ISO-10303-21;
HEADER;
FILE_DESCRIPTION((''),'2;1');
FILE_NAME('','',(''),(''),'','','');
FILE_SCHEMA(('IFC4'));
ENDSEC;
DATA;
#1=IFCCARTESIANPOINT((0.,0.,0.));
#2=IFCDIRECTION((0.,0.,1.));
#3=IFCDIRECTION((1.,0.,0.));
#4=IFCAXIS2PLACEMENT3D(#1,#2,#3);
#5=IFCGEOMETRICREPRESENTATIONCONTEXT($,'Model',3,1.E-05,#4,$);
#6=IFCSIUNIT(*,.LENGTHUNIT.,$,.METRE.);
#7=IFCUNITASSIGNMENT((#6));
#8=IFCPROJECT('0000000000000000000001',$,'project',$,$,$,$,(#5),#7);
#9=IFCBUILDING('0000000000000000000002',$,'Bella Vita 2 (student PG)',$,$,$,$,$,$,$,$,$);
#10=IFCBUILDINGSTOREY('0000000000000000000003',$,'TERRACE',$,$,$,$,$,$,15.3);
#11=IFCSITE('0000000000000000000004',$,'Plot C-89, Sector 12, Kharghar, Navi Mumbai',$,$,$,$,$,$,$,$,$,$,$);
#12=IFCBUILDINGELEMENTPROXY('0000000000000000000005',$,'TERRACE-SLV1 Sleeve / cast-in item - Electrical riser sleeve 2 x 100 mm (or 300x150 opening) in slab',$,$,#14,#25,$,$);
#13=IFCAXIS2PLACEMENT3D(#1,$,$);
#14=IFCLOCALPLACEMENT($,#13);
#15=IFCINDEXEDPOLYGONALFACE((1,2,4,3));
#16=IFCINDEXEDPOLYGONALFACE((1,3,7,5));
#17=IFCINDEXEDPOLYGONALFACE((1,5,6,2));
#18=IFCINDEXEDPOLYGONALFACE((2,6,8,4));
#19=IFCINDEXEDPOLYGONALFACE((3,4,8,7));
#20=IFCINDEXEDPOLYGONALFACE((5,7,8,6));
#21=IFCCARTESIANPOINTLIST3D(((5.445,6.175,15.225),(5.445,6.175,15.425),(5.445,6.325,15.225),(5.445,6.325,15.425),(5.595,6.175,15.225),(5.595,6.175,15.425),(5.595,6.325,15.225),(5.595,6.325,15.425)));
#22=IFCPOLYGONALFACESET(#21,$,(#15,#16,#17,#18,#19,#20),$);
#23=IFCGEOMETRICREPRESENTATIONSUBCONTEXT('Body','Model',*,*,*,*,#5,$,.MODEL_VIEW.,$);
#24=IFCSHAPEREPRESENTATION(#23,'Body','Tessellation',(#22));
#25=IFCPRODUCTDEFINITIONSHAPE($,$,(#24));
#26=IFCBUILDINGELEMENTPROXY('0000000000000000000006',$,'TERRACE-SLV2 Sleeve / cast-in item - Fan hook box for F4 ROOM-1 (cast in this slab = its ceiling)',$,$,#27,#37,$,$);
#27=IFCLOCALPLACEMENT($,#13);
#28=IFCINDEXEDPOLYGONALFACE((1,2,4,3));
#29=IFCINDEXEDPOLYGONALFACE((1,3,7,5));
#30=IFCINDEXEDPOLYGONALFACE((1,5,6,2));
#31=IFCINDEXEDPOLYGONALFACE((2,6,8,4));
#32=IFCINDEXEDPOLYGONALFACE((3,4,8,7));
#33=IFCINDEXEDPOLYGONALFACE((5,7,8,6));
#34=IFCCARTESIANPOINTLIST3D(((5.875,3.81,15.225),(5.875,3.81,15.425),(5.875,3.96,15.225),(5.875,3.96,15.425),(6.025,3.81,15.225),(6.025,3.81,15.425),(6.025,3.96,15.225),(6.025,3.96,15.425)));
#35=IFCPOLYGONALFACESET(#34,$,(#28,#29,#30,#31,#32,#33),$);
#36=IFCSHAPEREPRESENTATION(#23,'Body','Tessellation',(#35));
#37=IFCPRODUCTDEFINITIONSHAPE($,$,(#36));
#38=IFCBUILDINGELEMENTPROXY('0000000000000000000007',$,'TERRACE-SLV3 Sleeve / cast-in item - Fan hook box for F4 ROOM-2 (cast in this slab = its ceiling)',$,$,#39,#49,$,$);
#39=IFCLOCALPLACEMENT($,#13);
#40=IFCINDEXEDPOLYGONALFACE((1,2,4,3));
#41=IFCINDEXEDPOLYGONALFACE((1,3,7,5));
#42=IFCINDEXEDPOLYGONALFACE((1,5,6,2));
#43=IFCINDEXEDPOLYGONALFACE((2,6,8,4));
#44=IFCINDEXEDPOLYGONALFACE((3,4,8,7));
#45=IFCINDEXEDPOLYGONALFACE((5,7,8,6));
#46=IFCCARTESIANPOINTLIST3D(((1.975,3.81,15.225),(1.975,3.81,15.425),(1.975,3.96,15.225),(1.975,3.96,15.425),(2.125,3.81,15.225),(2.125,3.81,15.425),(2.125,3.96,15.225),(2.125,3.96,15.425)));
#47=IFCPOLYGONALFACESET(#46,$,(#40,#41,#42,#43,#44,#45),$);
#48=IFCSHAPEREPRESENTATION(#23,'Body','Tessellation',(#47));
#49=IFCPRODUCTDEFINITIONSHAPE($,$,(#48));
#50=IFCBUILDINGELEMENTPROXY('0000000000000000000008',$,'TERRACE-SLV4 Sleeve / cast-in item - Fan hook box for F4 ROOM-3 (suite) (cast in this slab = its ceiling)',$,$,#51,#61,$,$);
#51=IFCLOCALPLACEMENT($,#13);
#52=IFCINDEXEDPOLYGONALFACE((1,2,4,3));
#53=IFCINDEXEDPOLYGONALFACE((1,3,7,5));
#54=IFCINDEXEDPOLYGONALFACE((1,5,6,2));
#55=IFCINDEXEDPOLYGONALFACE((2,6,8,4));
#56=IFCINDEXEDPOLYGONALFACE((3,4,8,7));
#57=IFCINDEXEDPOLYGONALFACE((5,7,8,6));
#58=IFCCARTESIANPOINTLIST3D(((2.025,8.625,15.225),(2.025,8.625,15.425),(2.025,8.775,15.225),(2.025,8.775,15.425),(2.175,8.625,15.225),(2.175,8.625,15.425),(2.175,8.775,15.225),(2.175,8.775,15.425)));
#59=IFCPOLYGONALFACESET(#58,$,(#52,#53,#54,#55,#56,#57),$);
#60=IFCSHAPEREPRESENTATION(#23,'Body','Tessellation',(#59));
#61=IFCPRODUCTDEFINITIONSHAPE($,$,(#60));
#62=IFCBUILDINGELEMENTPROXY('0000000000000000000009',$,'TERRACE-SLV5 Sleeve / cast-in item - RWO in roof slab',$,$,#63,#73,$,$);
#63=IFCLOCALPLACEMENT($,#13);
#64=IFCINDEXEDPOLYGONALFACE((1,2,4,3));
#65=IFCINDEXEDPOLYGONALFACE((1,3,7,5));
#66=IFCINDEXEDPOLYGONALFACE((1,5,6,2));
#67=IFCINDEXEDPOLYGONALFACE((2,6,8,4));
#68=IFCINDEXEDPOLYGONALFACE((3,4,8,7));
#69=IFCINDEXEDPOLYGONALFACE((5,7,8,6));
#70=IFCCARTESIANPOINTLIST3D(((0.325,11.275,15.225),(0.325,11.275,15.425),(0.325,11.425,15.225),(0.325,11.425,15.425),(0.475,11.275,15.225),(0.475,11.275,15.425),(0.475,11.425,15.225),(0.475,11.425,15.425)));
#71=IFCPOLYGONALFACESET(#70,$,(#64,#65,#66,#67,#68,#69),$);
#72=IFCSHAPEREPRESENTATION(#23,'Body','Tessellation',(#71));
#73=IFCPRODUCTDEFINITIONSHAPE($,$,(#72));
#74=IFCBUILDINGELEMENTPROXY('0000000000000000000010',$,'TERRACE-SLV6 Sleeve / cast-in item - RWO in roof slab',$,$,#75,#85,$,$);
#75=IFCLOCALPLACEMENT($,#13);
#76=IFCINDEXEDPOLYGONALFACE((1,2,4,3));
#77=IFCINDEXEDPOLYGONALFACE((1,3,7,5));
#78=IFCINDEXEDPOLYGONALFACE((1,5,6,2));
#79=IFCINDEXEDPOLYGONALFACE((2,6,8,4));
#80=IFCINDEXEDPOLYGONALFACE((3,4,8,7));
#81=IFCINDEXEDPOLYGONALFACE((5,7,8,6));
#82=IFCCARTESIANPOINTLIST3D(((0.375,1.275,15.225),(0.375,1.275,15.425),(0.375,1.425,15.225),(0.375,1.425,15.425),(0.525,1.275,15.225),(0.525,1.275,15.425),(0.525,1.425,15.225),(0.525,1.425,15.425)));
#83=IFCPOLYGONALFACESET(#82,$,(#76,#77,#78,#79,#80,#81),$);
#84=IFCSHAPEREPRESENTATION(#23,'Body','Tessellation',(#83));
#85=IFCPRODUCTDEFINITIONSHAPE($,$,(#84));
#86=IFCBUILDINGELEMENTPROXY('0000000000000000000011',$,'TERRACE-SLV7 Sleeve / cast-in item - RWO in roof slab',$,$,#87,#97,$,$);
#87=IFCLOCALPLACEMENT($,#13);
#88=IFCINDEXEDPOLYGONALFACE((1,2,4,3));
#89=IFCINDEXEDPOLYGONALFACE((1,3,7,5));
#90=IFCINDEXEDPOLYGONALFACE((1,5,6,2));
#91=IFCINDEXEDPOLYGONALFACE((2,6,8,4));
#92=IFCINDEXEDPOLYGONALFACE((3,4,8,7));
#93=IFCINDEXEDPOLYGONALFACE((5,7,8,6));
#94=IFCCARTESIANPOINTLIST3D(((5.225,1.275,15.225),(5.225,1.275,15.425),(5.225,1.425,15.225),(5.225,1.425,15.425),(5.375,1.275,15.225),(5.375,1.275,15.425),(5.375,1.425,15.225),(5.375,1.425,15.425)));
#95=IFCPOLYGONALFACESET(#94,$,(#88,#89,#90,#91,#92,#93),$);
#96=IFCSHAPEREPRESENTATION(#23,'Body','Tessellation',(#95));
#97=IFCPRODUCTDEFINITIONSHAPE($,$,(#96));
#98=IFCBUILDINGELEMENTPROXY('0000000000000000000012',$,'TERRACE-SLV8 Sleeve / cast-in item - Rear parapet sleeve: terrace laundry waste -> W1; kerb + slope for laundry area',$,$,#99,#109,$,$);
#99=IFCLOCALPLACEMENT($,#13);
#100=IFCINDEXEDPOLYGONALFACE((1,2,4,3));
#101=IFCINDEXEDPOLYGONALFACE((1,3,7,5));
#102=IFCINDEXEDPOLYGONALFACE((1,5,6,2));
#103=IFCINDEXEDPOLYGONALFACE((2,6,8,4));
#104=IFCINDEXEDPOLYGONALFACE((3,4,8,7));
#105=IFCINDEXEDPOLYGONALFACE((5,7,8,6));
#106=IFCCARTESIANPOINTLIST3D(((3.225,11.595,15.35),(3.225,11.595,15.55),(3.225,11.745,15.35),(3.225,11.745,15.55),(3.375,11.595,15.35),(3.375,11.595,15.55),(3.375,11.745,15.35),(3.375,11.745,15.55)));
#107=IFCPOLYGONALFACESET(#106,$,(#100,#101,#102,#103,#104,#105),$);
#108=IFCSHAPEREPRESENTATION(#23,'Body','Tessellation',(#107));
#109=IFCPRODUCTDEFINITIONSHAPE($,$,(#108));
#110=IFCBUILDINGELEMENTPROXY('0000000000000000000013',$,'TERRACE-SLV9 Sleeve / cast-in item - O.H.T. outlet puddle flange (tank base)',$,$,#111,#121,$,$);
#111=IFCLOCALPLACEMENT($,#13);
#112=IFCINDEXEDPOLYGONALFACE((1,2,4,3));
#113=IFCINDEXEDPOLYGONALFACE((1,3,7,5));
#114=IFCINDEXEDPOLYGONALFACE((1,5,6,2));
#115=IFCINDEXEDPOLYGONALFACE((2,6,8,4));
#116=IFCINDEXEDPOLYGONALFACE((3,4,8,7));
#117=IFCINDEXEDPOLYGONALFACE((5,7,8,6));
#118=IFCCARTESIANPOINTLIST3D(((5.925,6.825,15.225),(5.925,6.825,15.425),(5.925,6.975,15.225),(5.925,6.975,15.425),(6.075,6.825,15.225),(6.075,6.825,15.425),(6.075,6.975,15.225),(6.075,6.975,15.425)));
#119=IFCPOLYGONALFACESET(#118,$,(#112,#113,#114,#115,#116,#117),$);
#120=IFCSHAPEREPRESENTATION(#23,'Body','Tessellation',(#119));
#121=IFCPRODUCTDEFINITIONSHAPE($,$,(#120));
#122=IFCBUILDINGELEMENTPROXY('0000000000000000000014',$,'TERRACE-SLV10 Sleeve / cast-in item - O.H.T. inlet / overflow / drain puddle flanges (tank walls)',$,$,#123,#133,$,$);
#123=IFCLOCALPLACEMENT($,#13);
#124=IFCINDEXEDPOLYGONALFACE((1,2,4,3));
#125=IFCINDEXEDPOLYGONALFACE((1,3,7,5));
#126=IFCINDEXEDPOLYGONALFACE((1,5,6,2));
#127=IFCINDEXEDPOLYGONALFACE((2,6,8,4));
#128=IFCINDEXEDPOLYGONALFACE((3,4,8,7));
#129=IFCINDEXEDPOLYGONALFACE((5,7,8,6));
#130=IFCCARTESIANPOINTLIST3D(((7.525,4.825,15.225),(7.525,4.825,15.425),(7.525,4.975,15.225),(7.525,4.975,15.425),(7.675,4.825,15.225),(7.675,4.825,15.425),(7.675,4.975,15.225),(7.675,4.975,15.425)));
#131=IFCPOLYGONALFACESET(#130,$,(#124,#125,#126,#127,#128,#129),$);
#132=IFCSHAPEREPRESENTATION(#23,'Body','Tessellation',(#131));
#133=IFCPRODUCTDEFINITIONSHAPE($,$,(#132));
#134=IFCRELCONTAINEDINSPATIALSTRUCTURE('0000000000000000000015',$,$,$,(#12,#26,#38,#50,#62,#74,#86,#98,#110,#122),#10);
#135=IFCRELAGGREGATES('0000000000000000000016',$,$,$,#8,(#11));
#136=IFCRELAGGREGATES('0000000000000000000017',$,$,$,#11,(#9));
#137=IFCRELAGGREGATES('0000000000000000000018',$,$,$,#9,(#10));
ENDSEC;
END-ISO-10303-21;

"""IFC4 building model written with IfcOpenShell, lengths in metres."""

from ifc_helpers import new_model, si_unit, frame, origin, origin_with_axes, origin_2d, place, context, subcontext, project, spatial, rectangle, extrude, element, save


model = new_model("IFC4")

# Units and contexts
model_context = context("Model", 3, precision=1e-05, world=origin_with_axes())
body_context = subcontext(model_context, "Body", "Model", "MODEL_VIEW")
ifc_project = project(units=[si_unit("LENGTHUNIT", "METRE")], contexts=[model_context])

# Site, building, storey
site = spatial("IfcSite", under=ifc_project, Name="Plot C-89, Sector 12, Kharghar, Navi Mumbai")
building = spatial("IfcBuilding", under=site, Name="Bella Vita 2 (student PG)")
storey = spatial("IfcBuildingStorey", under=building, Name="TERRACE", Elevation=15.3)

# Building element proxies
proxy_1_placement = place(None, origin())
element("IfcBuildingElementProxy", 1, at=proxy_1_placement, inside=storey, Name="TERRACE-SLV1 Sleeve / cast-in item - Electrical riser sleeve 2 x 100 mm (or 300x150 opening) in slab", context=body_context, shape_type="SweptSolid", body=[
    extrude(rectangle(XDim=0.15, YDim=0.15, at=origin_2d()), frame((5.52, 6.25, 15.225)), (0.0, 0.0, 1.0), 0.2),
])
proxy_2_placement = place(None, origin())
element("IfcBuildingElementProxy", 2, at=proxy_2_placement, inside=storey, Name="TERRACE-SLV2 Sleeve / cast-in item - Fan hook box for F4 ROOM-1 (cast in this slab = its ceiling)", context=body_context, shape_type="SweptSolid", body=[
    extrude(rectangle(XDim=0.15, YDim=0.15, at=origin_2d()), frame((5.95, 3.885, 15.225)), (0.0, 0.0, 1.0), 0.2),
])
proxy_3_placement = place(None, origin())
element("IfcBuildingElementProxy", 3, at=proxy_3_placement, inside=storey, Name="TERRACE-SLV3 Sleeve / cast-in item - Fan hook box for F4 ROOM-2 (cast in this slab = its ceiling)", context=body_context, shape_type="SweptSolid", body=[
    extrude(rectangle(XDim=0.15, YDim=0.15, at=origin_2d()), frame((2.05, 3.885, 15.225)), (0.0, 0.0, 1.0), 0.2),
])
proxy_4_placement = place(None, origin())
element("IfcBuildingElementProxy", 4, at=proxy_4_placement, inside=storey, Name="TERRACE-SLV4 Sleeve / cast-in item - Fan hook box for F4 ROOM-3 (suite) (cast in this slab = its ceiling)", context=body_context, shape_type="SweptSolid", body=[
    extrude(rectangle(XDim=0.15, YDim=0.15, at=origin_2d()), frame((2.1, 8.7, 15.225)), (0.0, 0.0, 1.0), 0.2),
])
proxy_5_placement = place(None, origin())
element("IfcBuildingElementProxy", 5, at=proxy_5_placement, inside=storey, Name="TERRACE-SLV5 Sleeve / cast-in item - RWO in roof slab", context=body_context, shape_type="SweptSolid", body=[
    extrude(rectangle(XDim=0.15, YDim=0.15, at=origin_2d()), frame((0.4, 11.35, 15.225)), (0.0, 0.0, 1.0), 0.2),
])
proxy_6_placement = place(None, origin())
element("IfcBuildingElementProxy", 6, at=proxy_6_placement, inside=storey, Name="TERRACE-SLV6 Sleeve / cast-in item - RWO in roof slab", context=body_context, shape_type="SweptSolid", body=[
    extrude(rectangle(XDim=0.15, YDim=0.15, at=origin_2d()), frame((0.45, 1.35, 15.225)), (0.0, 0.0, 1.0), 0.2),
])
proxy_7_placement = place(None, origin())
element("IfcBuildingElementProxy", 7, at=proxy_7_placement, inside=storey, Name="TERRACE-SLV7 Sleeve / cast-in item - RWO in roof slab", context=body_context, shape_type="SweptSolid", body=[
    extrude(rectangle(XDim=0.15, YDim=0.15, at=origin_2d()), frame((5.3, 1.35, 15.225)), (0.0, 0.0, 1.0), 0.2),
])
proxy_8_placement = place(None, origin())
element("IfcBuildingElementProxy", 8, at=proxy_8_placement, inside=storey, Name="TERRACE-SLV8 Sleeve / cast-in item - Rear parapet sleeve: terrace laundry waste -> W1; kerb + slope for laundry area", context=body_context, shape_type="SweptSolid", body=[
    extrude(rectangle(XDim=0.15, YDim=0.15, at=origin_2d()), frame((3.3, 11.67, 15.35)), (0.0, 0.0, 1.0), 0.2),
])
proxy_9_placement = place(None, origin())
element("IfcBuildingElementProxy", 9, at=proxy_9_placement, inside=storey, Name="TERRACE-SLV9 Sleeve / cast-in item - O.H.T. outlet puddle flange (tank base)", context=body_context, shape_type="SweptSolid", body=[
    extrude(rectangle(XDim=0.15, YDim=0.15, at=origin_2d()), frame((6.0, 6.9, 15.225)), (0.0, 0.0, 1.0), 0.2),
])
proxy_10_placement = place(None, origin())
element("IfcBuildingElementProxy", 10, at=proxy_10_placement, inside=storey, Name="TERRACE-SLV10 Sleeve / cast-in item - O.H.T. inlet / overflow / drain puddle flanges (tank walls)", context=body_context, shape_type="SweptSolid", body=[
    extrude(rectangle(XDim=0.15, YDim=0.15, at=origin_2d()), frame((7.6, 4.9, 15.225)), (0.0, 0.0, 1.0), 0.2),
])

save(model, "model.ifc")
